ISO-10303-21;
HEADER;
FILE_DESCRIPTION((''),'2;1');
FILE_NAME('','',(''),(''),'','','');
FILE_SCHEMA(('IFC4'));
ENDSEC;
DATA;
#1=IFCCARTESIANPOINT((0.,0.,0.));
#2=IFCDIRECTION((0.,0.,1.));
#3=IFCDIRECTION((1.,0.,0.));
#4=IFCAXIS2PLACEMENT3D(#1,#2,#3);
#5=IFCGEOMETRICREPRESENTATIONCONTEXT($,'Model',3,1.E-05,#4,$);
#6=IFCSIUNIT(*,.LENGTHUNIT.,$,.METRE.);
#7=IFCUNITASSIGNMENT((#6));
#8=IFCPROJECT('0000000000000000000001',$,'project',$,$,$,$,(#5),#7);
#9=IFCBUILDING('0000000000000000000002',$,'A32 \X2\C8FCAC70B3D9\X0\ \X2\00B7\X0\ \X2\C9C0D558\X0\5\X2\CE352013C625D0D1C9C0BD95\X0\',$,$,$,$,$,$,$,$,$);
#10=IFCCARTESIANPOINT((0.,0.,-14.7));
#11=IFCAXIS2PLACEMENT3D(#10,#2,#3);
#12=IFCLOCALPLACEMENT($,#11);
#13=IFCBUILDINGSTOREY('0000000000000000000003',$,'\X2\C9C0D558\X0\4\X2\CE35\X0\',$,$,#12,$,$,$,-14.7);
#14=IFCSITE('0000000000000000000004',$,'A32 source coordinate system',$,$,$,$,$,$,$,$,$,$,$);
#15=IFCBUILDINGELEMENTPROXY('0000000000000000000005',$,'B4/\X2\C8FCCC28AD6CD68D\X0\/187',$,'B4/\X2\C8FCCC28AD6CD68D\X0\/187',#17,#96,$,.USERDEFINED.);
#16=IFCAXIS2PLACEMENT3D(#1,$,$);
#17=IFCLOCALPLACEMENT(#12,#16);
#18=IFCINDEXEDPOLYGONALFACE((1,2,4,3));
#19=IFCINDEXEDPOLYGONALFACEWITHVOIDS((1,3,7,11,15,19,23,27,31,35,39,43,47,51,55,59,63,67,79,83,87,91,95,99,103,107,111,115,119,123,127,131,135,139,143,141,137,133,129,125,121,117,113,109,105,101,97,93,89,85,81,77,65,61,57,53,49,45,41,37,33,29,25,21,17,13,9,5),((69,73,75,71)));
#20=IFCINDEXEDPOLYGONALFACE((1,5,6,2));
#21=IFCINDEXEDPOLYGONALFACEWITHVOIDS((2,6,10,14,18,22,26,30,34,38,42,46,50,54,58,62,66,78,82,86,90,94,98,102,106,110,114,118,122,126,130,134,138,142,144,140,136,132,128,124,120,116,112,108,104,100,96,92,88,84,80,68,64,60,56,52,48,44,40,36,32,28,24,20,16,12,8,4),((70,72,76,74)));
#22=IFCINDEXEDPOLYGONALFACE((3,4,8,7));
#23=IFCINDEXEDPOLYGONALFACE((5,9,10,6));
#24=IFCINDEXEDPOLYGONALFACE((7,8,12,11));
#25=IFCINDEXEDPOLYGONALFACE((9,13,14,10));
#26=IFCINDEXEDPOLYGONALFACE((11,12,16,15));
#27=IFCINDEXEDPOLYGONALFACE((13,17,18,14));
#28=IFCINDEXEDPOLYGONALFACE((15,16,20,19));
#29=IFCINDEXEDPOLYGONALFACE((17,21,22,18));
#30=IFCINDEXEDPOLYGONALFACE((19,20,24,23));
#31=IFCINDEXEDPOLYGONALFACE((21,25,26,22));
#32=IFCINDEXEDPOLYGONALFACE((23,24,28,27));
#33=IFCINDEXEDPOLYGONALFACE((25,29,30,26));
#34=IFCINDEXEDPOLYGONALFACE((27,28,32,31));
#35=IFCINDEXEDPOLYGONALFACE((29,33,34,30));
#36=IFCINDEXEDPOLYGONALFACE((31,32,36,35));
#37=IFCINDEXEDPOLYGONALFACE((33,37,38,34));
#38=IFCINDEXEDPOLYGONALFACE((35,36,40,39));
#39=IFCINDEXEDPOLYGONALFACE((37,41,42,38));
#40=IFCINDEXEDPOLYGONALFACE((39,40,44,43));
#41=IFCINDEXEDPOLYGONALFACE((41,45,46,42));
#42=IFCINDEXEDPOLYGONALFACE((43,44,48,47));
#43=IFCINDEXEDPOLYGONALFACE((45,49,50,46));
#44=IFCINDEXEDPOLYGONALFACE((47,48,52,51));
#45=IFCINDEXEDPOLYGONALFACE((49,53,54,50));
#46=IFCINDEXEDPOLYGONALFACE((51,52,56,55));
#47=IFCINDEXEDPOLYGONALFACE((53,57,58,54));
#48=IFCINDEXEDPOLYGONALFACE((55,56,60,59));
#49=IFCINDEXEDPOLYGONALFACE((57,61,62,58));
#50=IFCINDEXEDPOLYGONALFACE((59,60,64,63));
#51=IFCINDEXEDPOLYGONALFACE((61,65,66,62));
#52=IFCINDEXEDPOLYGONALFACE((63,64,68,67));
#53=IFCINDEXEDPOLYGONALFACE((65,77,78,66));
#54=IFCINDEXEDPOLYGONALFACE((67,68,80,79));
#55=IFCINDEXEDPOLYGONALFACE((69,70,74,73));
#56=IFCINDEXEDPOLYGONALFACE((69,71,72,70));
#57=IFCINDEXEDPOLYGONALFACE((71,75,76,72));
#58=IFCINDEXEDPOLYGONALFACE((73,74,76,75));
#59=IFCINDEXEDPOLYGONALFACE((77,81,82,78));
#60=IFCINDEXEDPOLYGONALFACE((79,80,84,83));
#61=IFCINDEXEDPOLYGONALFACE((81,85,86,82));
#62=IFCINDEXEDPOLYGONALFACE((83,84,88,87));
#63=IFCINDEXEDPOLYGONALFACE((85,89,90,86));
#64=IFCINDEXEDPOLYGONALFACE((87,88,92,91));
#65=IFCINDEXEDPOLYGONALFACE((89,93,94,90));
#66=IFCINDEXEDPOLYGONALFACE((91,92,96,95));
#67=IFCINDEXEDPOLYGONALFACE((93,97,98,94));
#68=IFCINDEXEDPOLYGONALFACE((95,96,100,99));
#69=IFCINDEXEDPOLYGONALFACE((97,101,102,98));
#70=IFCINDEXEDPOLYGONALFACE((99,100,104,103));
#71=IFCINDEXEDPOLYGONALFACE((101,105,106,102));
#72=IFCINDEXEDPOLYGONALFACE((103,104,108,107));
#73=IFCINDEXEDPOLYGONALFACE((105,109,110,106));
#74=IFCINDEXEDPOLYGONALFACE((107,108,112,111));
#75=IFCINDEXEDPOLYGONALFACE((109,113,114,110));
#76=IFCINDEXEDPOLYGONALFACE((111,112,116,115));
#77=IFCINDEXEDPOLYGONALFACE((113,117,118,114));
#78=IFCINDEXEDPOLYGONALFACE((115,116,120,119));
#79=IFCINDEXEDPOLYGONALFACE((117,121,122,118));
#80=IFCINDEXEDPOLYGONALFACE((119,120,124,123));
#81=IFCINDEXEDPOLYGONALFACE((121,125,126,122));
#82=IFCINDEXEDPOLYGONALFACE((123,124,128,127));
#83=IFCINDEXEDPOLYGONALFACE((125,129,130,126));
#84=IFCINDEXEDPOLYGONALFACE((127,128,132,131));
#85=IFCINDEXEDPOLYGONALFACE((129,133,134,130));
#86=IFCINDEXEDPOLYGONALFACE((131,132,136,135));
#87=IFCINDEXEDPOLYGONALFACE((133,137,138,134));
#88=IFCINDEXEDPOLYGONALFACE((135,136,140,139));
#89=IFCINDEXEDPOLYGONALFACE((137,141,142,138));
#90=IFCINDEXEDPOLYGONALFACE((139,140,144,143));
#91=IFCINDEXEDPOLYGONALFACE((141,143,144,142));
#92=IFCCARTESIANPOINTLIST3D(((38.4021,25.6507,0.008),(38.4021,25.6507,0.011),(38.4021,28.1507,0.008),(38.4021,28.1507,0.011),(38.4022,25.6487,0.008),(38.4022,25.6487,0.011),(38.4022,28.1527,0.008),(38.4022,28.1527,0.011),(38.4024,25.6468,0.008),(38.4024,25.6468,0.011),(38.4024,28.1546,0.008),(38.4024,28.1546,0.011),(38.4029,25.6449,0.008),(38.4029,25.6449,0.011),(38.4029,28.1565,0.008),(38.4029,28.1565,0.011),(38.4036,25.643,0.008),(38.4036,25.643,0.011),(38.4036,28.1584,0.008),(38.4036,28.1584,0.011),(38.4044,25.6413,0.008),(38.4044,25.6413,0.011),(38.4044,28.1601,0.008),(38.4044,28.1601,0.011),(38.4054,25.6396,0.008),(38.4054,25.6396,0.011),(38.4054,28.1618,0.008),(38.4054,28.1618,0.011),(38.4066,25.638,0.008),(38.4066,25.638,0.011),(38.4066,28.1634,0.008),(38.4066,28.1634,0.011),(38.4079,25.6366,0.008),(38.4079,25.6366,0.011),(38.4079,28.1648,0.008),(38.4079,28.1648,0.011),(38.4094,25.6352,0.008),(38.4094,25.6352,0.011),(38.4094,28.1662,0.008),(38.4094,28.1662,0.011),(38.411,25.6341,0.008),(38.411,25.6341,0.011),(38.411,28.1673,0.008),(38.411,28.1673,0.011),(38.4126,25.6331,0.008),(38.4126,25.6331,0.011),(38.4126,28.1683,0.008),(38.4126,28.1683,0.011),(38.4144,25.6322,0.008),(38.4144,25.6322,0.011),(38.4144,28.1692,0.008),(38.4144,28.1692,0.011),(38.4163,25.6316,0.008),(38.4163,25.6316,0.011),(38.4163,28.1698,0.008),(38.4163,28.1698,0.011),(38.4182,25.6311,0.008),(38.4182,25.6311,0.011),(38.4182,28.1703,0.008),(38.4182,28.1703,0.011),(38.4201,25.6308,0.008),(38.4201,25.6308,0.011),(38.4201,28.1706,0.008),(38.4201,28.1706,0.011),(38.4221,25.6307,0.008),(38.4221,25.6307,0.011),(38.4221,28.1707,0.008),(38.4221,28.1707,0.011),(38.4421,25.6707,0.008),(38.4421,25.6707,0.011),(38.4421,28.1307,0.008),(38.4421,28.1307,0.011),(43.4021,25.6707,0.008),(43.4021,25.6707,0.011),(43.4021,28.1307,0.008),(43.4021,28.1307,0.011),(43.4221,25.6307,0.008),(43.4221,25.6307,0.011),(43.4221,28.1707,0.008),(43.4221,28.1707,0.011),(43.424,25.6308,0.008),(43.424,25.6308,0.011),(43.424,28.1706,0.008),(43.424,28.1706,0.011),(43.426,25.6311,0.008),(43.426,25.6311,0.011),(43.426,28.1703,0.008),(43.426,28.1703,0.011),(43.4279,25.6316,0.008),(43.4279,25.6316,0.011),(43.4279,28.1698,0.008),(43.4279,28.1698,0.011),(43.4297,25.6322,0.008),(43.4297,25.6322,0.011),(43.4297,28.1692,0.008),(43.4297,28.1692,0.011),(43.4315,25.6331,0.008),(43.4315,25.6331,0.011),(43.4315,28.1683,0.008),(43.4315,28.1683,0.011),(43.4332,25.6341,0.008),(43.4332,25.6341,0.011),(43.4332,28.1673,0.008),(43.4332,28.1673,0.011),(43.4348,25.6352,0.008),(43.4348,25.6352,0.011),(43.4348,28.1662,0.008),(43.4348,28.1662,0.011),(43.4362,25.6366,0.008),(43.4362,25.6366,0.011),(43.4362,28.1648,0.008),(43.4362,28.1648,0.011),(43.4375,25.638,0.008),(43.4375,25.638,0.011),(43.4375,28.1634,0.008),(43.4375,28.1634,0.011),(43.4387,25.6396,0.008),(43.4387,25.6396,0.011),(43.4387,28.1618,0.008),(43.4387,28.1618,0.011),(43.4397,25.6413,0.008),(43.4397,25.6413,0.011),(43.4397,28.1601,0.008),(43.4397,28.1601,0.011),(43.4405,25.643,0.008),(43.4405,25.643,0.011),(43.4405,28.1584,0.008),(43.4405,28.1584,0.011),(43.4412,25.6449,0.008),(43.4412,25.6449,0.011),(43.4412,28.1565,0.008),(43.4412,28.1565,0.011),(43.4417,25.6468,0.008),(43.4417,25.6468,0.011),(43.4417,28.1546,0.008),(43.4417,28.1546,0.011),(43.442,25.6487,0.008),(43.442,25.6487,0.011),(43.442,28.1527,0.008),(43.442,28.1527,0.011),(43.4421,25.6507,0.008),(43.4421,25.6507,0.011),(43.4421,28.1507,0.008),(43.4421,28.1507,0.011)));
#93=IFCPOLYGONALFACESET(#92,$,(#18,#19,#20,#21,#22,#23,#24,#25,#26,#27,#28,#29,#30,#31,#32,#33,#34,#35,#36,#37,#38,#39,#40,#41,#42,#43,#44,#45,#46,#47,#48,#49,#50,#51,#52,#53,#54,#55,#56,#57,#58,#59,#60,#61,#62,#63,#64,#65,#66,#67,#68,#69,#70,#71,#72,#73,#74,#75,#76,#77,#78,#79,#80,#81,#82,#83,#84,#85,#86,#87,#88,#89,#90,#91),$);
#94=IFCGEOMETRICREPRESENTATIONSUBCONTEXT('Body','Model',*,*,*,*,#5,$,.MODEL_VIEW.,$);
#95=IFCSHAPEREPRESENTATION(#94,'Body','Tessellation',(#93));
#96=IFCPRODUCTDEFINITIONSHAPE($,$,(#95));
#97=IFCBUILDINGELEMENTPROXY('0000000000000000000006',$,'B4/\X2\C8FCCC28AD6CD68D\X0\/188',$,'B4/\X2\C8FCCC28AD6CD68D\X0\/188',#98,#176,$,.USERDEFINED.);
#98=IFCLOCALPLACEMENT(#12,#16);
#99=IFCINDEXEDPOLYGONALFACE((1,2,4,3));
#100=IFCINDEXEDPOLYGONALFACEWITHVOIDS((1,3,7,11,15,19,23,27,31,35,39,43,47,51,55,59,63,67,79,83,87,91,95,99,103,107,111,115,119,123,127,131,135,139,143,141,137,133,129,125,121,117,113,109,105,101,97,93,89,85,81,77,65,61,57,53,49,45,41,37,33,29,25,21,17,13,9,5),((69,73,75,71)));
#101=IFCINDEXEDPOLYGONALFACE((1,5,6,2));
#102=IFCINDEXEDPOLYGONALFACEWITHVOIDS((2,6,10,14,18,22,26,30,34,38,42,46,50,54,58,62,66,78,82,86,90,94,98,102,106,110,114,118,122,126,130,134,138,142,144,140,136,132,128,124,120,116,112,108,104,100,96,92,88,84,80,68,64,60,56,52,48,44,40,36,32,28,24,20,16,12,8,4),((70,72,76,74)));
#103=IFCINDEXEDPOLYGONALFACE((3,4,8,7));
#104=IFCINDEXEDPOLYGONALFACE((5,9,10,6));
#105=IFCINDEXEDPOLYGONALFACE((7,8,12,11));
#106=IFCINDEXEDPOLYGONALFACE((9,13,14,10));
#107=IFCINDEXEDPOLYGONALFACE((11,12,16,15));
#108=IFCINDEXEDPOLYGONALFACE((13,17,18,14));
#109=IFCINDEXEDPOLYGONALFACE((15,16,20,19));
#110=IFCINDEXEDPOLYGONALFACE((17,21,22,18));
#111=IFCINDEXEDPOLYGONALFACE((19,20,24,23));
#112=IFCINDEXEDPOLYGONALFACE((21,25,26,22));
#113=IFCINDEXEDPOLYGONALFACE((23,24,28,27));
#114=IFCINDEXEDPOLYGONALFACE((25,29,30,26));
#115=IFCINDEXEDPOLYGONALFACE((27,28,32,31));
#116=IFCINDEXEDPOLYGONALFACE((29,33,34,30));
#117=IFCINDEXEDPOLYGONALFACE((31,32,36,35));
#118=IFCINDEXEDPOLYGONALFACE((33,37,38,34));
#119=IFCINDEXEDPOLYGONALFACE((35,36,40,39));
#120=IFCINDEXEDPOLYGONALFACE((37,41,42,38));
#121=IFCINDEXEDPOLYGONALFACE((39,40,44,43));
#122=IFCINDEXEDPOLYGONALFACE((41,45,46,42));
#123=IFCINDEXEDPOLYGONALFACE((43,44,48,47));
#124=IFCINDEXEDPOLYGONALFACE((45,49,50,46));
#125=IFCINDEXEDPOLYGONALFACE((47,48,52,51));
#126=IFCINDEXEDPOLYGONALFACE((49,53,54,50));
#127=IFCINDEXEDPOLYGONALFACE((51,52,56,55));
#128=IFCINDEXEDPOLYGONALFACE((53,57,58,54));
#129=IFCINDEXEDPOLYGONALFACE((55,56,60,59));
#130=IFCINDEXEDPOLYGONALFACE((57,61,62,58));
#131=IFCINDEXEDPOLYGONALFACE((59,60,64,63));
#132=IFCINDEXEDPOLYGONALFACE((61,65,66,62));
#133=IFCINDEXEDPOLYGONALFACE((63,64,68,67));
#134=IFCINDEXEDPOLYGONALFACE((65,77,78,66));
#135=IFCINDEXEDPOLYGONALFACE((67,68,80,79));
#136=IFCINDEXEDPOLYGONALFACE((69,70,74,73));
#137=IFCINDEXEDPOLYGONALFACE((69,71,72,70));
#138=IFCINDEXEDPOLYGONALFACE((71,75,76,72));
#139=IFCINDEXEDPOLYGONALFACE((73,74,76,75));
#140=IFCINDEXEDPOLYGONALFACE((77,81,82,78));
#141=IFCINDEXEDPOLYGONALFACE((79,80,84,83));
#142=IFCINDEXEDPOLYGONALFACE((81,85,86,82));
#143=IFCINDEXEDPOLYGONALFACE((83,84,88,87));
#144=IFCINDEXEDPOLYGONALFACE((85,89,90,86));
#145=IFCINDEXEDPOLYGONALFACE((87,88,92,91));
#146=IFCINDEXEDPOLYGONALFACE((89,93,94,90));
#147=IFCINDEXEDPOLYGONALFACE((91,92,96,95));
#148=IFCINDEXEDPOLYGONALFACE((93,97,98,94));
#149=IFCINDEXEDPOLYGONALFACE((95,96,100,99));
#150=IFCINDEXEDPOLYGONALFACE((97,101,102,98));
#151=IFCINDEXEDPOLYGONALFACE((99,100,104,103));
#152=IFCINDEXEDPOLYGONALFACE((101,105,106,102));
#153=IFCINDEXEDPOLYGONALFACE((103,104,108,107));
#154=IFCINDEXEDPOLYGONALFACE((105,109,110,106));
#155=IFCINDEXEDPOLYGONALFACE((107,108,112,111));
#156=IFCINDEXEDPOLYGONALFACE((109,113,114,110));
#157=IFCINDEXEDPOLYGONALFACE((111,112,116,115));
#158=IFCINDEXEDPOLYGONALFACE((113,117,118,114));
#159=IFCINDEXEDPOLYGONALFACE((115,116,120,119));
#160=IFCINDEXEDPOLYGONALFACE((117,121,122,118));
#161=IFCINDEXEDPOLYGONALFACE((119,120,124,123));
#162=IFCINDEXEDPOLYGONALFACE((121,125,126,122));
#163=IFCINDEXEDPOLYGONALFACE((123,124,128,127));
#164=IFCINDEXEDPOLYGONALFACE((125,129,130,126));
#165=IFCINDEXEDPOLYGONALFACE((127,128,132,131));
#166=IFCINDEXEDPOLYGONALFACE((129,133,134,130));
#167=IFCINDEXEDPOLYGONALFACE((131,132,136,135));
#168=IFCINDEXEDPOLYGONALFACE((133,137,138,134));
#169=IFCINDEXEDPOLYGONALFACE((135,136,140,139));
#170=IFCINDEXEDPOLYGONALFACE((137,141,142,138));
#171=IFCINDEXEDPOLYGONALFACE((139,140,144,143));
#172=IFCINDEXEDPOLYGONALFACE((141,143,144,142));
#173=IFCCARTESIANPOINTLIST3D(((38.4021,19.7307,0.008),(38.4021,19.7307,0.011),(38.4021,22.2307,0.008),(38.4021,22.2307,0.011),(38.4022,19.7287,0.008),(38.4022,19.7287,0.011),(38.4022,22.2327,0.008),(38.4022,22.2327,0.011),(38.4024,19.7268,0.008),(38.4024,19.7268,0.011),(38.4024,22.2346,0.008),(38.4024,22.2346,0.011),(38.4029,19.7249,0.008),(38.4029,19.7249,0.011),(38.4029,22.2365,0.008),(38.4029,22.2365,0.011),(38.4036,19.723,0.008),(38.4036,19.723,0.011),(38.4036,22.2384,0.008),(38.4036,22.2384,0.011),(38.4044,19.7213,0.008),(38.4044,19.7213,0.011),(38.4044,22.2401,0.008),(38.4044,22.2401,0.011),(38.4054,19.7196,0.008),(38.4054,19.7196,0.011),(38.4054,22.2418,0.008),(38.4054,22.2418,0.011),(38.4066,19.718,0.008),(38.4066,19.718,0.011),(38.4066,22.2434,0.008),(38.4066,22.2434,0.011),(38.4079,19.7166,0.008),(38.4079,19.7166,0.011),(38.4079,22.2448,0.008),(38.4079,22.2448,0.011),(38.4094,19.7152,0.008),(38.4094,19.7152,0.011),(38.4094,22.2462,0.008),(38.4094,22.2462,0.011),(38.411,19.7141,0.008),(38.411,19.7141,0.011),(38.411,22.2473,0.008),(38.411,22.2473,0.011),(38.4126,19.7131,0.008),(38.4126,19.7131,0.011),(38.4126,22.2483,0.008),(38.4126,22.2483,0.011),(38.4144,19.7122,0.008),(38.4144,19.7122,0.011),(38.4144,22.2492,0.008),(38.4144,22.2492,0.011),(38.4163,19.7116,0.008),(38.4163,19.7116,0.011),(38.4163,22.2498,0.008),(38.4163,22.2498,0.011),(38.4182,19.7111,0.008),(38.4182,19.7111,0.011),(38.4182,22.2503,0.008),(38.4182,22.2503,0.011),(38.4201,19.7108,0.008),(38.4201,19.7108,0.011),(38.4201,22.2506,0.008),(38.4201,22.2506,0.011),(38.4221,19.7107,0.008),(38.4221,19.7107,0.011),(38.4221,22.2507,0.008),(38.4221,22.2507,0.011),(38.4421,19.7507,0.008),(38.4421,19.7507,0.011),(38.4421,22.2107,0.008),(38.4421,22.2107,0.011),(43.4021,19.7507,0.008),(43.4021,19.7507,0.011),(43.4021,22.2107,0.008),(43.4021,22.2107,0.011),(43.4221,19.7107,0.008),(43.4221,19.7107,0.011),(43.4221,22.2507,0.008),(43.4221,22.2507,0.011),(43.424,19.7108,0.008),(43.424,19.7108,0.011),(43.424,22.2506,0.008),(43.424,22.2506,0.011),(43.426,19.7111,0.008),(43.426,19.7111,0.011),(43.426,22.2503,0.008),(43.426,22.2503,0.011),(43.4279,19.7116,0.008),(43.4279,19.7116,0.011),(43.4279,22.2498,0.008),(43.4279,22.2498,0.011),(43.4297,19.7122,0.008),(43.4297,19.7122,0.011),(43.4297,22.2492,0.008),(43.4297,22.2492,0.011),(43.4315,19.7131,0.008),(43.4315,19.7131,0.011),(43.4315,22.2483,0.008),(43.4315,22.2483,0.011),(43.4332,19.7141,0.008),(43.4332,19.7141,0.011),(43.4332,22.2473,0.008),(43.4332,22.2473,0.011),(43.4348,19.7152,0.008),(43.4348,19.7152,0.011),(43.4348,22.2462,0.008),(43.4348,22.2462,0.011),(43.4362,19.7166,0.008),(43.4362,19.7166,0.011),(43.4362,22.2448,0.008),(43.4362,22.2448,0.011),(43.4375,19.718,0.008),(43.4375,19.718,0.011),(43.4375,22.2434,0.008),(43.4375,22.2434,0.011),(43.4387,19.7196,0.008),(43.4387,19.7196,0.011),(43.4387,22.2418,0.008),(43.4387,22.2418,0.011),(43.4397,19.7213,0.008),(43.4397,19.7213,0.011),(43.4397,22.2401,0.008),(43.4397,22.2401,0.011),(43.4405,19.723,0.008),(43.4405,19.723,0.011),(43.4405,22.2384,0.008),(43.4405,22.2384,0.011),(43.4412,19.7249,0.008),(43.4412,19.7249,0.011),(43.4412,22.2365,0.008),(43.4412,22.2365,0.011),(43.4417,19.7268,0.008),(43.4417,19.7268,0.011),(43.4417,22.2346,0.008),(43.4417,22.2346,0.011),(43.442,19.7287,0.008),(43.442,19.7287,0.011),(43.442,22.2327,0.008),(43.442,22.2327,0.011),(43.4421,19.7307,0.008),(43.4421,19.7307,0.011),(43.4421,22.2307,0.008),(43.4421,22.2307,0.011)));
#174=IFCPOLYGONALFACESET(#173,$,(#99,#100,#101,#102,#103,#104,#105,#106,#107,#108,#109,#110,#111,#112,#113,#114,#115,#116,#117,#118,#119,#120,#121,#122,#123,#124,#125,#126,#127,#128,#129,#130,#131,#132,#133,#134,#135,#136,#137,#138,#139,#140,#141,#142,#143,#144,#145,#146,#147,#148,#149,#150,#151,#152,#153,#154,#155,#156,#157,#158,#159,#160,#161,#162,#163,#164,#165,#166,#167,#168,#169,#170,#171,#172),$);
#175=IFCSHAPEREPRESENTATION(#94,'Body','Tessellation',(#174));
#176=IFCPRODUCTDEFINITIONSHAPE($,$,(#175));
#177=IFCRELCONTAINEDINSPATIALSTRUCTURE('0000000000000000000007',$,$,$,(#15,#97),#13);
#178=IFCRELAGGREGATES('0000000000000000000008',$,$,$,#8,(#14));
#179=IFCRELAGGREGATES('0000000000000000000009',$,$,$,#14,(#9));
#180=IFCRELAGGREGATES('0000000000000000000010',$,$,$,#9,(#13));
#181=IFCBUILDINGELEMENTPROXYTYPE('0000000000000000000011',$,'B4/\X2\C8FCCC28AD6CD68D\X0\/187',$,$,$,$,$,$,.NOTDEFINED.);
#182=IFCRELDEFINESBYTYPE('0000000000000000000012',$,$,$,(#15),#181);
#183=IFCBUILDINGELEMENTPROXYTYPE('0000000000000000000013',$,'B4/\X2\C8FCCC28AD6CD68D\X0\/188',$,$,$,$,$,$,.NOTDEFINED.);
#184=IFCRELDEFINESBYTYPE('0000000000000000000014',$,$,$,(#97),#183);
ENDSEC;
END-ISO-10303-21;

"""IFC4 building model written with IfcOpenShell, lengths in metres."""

from ifc_helpers import new_model, si_unit, frame, origin, origin_with_axes, place, context, subcontext, project, spatial, polyline, outline, extrude, source, transform, mapped, type_object, type_shapes, element, save


model = new_model("IFC4")

# Units and contexts
model_context = context("Model", 3, precision=1e-05, world=origin_with_axes())
body_context = subcontext(model_context, "Body", "Model", "MODEL_VIEW")
ifc_project = project(units=[si_unit("LENGTHUNIT", "METRE")], contexts=[model_context])

# Site, building, storey
site = spatial("IfcSite", under=ifc_project, Name="A32 source coordinate system")
building = spatial("IfcBuilding", under=site, Name="A32 주거동 · 지하5층–옥탑지붕")
storey_placement = place(None, frame((0.0, 0.0, -14.7), z_axis=(0.0, 0.0, 1.0), x_axis=(1.0, 0.0, 0.0)))
storey = spatial("IfcBuildingStorey", under=building, at=storey_placement, Name="지하4층", Elevation=-14.7)

# Building element proxies
building_element_proxy_type_1 = type_object("IfcBuildingElementProxyType", Name="B4/주차구획/187", PredefinedType="NOTDEFINED")
shared_shape_1 = source(origin(), body_context, "Body", "SweptSolid", [
    extrude(outline(polyline([(43.4221, 28.1707), (43.424, 28.1706), (43.426, 28.1703), (43.4279, 28.1698), (43.4297, 28.1692), (43.4315, 28.1683), (43.4332, 28.1673), (43.4348, 28.1662), (43.4362, 28.1648), (43.4375, 28.1634), (43.4387, 28.1618), (43.4397, 28.1601), (43.4405, 28.1584), (43.4412, 28.1565), (43.4417, 28.1546), (43.442, 28.1527), (43.4421, 28.1507), (43.4421, 25.6507), (43.442, 25.6487), (43.4417, 25.6468), (43.4412, 25.6449), (43.4405, 25.643), (43.4397, 25.6413), (43.4387, 25.6396), (43.4375, 25.638), (43.4362, 25.6366), (43.4348, 25.6352), (43.4332, 25.6341), (43.4315, 25.6331), (43.4297, 25.6322), (43.4279, 25.6316), (43.426, 25.6311), (43.424, 25.6308), (43.4221, 25.6307), (38.4221, 25.6307), (38.4201, 25.6308), (38.4182, 25.6311), (38.4163, 25.6316), (38.4144, 25.6322), (38.4126, 25.6331), (38.411, 25.6341), (38.4094, 25.6352), (38.4079, 25.6366), (38.4066, 25.638), (38.4054, 25.6396), (38.4044, 25.6413), (38.4036, 25.643), (38.4029, 25.6449), (38.4024, 25.6468), (38.4022, 25.6487), (38.4021, 25.6507), (38.4021, 28.1507), (38.4022, 28.1527), (38.4024, 28.1546), (38.4029, 28.1565), (38.4036, 28.1584), (38.4044, 28.1601), (38.4054, 28.1618), (38.4066, 28.1634), (38.4079, 28.1648), (38.4094, 28.1662), (38.411, 28.1673), (38.4126, 28.1683), (38.4144, 28.1692), (38.4163, 28.1698), (38.4182, 28.1703), (38.4201, 28.1706), (38.4221, 28.1707), (43.4221, 28.1707)]), holes=[polyline([(43.4021, 28.1307), (38.4421, 28.1307), (38.4421, 25.6707), (43.4021, 25.6707), (43.4021, 28.1307)])]), frame((0.0, 0.0, 0.008)), (0.0, 0.0, 1.0), 0.003),
])
type_shapes(building_element_proxy_type_1, [shared_shape_1])
proxy_1_placement = place(storey_placement, origin_with_axes())
element("IfcBuildingElementProxy", 1, at=proxy_1_placement, inside=storey, type_object=building_element_proxy_type_1, Name="B4/주차구획/187", ObjectType="B4/주차구획/187", PredefinedType="USERDEFINED", context=body_context, shape_type="MappedRepresentation", body=[
    mapped(shared_shape_1, transform((0.0, 0.0, 0.0), scale=1.0)),
])
building_element_proxy_type_2 = type_object("IfcBuildingElementProxyType", Name="B4/주차구획/188", PredefinedType="NOTDEFINED")
shared_shape_2 = source(origin(), body_context, "Body", "SweptSolid", [
    extrude(outline(polyline([(43.4221, 22.2507), (43.424, 22.2506), (43.426, 22.2503), (43.4279, 22.2498), (43.4297, 22.2492), (43.4315, 22.2483), (43.4332, 22.2473), (43.4348, 22.2462), (43.4362, 22.2448), (43.4375, 22.2434), (43.4387, 22.2418), (43.4397, 22.2401), (43.4405, 22.2384), (43.4412, 22.2365), (43.4417, 22.2346), (43.442, 22.2327), (43.4421, 22.2307), (43.4421, 19.7307), (43.442, 19.7287), (43.4417, 19.7268), (43.4412, 19.7249), (43.4405, 19.723), (43.4397, 19.7213), (43.4387, 19.7196), (43.4375, 19.718), (43.4362, 19.7166), (43.4348, 19.7152), (43.4332, 19.7141), (43.4315, 19.7131), (43.4297, 19.7122), (43.4279, 19.7116), (43.426, 19.7111), (43.424, 19.7108), (43.4221, 19.7107), (38.4221, 19.7107), (38.4201, 19.7108), (38.4182, 19.7111), (38.4163, 19.7116), (38.4144, 19.7122), (38.4126, 19.7131), (38.411, 19.7141), (38.4094, 19.7152), (38.4079, 19.7166), (38.4066, 19.718), (38.4054, 19.7196), (38.4044, 19.7213), (38.4036, 19.723), (38.4029, 19.7249), (38.4024, 19.7268), (38.4022, 19.7287), (38.4021, 19.7307), (38.4021, 22.2307), (38.4022, 22.2327), (38.4024, 22.2346), (38.4029, 22.2365), (38.4036, 22.2384), (38.4044, 22.2401), (38.4054, 22.2418), (38.4066, 22.2434), (38.4079, 22.2448), (38.4094, 22.2462), (38.411, 22.2473), (38.4126, 22.2483), (38.4144, 22.2492), (38.4163, 22.2498), (38.4182, 22.2503), (38.4201, 22.2506), (38.4221, 22.2507), (43.4221, 22.2507)]), holes=[polyline([(43.4021, 22.2107), (38.4421, 22.2107), (38.4421, 19.7507), (43.4021, 19.7507), (43.4021, 22.2107)])]), frame((0.0, 0.0, 0.008)), (0.0, 0.0, 1.0), 0.003),
])
type_shapes(building_element_proxy_type_2, [shared_shape_2])
proxy_2_placement = place(storey_placement, origin_with_axes())
element("IfcBuildingElementProxy", 2, at=proxy_2_placement, inside=storey, type_object=building_element_proxy_type_2, Name="B4/주차구획/188", ObjectType="B4/주차구획/188", PredefinedType="USERDEFINED", context=body_context, shape_type="MappedRepresentation", body=[
    mapped(shared_shape_2, transform((0.0, 0.0, 0.0), scale=1.0)),
])

save(model, "model.ifc")
